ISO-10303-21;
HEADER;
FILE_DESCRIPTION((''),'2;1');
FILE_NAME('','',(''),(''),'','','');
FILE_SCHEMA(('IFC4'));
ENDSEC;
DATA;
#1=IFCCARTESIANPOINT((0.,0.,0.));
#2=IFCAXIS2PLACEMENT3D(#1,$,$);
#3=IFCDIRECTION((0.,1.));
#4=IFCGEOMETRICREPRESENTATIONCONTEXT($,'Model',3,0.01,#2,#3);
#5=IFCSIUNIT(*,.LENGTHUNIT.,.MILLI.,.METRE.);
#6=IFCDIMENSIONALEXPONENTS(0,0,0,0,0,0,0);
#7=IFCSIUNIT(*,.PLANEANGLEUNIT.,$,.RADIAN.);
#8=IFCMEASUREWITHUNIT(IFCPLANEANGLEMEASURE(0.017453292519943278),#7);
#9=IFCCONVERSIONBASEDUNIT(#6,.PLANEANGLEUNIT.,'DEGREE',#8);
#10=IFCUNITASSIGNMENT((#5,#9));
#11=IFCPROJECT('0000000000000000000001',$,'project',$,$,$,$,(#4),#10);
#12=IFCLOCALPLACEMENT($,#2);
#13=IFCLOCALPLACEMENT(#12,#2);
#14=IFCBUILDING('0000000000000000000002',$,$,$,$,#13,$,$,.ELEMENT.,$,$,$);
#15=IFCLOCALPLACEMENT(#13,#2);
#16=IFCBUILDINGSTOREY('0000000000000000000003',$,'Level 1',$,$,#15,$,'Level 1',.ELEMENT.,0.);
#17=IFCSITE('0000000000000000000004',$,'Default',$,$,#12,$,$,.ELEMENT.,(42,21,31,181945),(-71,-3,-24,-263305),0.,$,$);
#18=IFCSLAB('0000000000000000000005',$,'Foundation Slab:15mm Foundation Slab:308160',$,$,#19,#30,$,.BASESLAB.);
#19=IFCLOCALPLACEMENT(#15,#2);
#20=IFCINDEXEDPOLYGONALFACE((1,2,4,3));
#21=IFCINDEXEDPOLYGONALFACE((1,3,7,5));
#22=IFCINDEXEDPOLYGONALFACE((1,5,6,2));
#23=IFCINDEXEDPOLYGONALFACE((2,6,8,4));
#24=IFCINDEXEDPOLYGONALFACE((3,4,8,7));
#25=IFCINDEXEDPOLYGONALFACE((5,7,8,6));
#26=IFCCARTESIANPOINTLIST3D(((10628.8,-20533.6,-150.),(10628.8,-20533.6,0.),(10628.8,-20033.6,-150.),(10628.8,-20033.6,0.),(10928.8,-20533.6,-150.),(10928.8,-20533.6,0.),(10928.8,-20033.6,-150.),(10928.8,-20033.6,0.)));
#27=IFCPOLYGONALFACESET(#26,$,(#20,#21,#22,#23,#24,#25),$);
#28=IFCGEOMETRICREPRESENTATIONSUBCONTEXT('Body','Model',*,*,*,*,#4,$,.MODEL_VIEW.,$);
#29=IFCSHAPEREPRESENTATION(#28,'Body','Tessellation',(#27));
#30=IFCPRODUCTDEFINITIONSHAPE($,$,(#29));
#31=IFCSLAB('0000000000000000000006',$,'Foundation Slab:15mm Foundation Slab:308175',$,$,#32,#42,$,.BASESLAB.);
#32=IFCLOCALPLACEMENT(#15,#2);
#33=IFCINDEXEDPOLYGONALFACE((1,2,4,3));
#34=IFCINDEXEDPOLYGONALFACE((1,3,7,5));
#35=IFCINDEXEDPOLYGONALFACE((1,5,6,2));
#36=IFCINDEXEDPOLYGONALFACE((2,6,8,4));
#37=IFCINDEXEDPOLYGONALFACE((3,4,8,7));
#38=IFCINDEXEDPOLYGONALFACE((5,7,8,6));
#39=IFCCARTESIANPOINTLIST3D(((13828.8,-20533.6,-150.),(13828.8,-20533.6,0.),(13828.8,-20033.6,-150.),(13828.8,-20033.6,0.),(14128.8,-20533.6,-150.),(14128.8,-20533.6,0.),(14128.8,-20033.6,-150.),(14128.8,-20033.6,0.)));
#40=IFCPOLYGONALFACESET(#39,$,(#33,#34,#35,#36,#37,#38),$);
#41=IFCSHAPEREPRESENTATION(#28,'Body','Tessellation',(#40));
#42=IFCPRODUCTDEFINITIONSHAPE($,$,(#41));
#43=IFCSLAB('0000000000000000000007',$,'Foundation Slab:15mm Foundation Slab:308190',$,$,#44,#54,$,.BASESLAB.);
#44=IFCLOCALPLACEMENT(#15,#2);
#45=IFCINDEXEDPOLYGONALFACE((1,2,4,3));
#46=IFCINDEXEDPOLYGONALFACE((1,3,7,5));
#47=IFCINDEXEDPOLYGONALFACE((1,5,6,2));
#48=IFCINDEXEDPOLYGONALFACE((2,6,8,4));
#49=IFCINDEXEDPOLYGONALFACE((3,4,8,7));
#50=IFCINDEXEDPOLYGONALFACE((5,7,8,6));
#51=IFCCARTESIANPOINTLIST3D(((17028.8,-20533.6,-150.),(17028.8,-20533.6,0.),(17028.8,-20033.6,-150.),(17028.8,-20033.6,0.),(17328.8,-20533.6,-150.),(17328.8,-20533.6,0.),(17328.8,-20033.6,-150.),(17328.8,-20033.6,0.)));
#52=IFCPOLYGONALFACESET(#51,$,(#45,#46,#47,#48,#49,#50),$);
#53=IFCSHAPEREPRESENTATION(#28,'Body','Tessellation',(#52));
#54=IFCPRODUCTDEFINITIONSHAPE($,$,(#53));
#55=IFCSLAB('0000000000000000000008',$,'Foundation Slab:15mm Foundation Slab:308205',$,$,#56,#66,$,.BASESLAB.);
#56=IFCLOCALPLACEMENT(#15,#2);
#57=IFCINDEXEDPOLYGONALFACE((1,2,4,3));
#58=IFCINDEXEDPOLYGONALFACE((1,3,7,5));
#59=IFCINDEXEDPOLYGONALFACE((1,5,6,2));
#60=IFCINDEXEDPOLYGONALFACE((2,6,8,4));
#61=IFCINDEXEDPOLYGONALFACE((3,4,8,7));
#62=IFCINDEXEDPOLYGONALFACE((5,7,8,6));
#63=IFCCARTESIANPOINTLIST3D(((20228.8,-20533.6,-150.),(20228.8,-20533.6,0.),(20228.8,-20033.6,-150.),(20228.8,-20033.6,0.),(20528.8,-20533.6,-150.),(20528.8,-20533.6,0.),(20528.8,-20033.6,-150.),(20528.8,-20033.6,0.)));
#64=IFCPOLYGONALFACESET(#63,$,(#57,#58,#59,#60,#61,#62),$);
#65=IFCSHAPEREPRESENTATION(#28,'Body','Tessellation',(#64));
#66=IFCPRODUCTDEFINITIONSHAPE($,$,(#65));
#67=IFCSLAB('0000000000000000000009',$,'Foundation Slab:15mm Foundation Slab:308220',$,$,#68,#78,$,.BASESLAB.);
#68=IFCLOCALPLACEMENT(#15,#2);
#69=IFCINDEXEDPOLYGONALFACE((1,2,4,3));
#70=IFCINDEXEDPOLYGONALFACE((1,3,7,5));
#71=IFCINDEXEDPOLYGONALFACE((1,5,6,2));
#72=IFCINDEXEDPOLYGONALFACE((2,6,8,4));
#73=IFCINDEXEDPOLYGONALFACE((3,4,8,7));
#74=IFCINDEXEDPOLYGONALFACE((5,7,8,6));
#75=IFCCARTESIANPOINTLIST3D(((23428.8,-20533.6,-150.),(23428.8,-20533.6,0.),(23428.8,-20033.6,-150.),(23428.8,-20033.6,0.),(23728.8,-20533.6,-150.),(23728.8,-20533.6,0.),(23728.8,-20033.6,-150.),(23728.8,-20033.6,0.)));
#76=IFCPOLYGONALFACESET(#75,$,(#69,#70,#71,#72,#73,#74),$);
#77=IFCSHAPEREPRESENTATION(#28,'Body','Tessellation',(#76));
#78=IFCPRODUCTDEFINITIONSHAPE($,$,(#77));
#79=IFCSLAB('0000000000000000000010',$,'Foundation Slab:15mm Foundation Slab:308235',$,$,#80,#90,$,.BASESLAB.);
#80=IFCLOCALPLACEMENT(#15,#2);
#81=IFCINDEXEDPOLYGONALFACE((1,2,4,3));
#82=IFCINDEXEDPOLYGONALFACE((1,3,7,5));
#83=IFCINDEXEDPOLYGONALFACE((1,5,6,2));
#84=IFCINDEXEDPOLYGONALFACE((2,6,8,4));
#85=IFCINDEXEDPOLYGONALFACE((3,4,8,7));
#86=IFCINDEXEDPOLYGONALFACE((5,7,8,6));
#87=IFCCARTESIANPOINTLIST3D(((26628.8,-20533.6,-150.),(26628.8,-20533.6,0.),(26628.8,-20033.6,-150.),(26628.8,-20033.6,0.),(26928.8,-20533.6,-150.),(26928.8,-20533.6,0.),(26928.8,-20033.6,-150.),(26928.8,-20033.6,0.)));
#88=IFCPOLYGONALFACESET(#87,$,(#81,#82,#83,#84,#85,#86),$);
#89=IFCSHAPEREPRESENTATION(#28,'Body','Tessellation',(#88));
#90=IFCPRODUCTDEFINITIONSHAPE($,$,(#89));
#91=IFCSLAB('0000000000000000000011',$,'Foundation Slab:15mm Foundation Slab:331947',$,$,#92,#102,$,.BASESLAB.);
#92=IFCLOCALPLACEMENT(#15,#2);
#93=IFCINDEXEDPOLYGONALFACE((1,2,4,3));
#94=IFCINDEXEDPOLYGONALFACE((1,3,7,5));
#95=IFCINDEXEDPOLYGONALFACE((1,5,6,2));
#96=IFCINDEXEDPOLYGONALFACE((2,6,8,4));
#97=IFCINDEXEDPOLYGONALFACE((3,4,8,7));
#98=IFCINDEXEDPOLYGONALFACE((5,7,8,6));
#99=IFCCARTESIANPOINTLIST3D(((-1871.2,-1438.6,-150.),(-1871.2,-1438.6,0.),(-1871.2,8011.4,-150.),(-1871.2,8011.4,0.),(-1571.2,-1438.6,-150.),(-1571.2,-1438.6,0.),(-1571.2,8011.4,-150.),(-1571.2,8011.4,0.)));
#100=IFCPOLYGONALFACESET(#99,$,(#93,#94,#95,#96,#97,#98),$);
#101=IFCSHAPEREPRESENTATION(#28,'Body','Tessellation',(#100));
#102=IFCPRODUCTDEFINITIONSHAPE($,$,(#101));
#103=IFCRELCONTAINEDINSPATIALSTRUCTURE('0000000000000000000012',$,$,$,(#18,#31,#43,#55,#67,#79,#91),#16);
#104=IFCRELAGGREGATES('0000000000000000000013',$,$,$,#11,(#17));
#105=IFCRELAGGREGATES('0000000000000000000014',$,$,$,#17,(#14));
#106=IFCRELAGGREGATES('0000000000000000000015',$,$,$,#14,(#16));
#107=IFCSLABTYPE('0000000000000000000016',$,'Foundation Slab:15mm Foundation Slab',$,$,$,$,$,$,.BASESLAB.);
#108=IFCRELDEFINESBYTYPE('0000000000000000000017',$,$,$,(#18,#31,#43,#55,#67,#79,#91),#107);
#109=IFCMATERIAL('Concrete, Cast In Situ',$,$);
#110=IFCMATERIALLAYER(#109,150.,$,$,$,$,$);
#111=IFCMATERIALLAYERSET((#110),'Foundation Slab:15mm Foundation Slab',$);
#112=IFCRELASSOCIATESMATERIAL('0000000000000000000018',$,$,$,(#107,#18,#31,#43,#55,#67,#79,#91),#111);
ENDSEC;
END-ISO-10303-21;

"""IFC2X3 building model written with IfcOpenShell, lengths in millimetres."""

from ifc_helpers import new_model, entity, si_unit, converted_unit, direction, frame, frame_2d, origin, origin_2d_with_axis, place, context, subcontext, project, spatial, rectangle, extrude, material, layer, layer_set, layer_usage, type_object, element, save


model = new_model("IFC2X3")

# Units and contexts
model_context = context("Model", 3, precision=0.01, world=origin(), true_north=direction((0.0, 1.0)))
body_context = subcontext(model_context, "Body", "Model", "MODEL_VIEW")
ifc_project = project(units=[si_unit("LENGTHUNIT", "METRE", prefix="MILLI"), converted_unit("PLANEANGLEUNIT", "DEGREE", entity("IfcPlaneAngleMeasure", 0.017453292519943278), si_unit("PLANEANGLEUNIT", "RADIAN"), dimensions=[0, 0, 0, 0, 0, 0, 0])], contexts=[model_context])

# Site, building, storey
site_placement = place(None, origin())
site = spatial("IfcSite", under=ifc_project, at=site_placement, Name="Default", CompositionType="ELEMENT", RefLatitude=(42, 21, 31, 181945), RefLongitude=(-71, -3, -24, -263305), RefElevation=0.0)
building_placement = place(site_placement, origin())
building = spatial("IfcBuilding", under=site, at=building_placement, CompositionType="ELEMENT")
storey_placement = place(building_placement, origin())
storey = spatial("IfcBuildingStorey", under=building, at=storey_placement, Name="Level 1", LongName="Level 1", CompositionType="ELEMENT", Elevation=0.0)

# Slabs
ifc_material_1 = material(Name="Concrete, Cast In Situ")
ifc_layer = layer(ifc_material_1, 150.0)
ifc_layer_set = layer_set([ifc_layer], Name="Foundation Slab:15mm Foundation Slab")
slab_type = type_object("IfcSlabType", Name="Foundation Slab:15mm Foundation Slab", PredefinedType="BASESLAB", material=ifc_layer_set)
ifc_layer_usage_1 = layer_usage(ifc_layer_set, "AXIS3", "POSITIVE", 0.0)
slab_1_placement = place(storey_placement, origin())
element("IfcSlab", 1, at=slab_1_placement, inside=storey, type_object=slab_type, material=ifc_layer_usage_1, Name="Foundation Slab:15mm Foundation Slab:308160", PredefinedType="BASESLAB", context=body_context, shape_type="SweptSolid", body=[
    extrude(rectangle(XDim=500.0, YDim=300.0, at=origin_2d_with_axis()), frame((10778.8, -20283.6, 0.0), z_axis=(0.0, 0.0, -1.0), x_axis=(0.0, 1.0, 0.0)), (0.0, 0.0, 1.0), 150.0),
])
ifc_layer_usage_2 = layer_usage(ifc_layer_set, "AXIS3", "POSITIVE", 0.0)
slab_2_placement = place(storey_placement, origin())
element("IfcSlab", 2, at=slab_2_placement, inside=storey, type_object=slab_type, material=ifc_layer_usage_2, Name="Foundation Slab:15mm Foundation Slab:308175", PredefinedType="BASESLAB", context=body_context, shape_type="SweptSolid", body=[
    extrude(rectangle(XDim=500.0, YDim=300.0, at=origin_2d_with_axis()), frame((13978.8, -20283.6, 0.0), z_axis=(0.0, 0.0, -1.0), x_axis=(0.0, 1.0, 0.0)), (0.0, 0.0, 1.0), 150.0),
])
ifc_layer_usage_3 = layer_usage(ifc_layer_set, "AXIS3", "POSITIVE", 0.0)
slab_3_placement = place(storey_placement, origin())
element("IfcSlab", 3, at=slab_3_placement, inside=storey, type_object=slab_type, material=ifc_layer_usage_3, Name="Foundation Slab:15mm Foundation Slab:308190", PredefinedType="BASESLAB", context=body_context, shape_type="SweptSolid", body=[
    extrude(rectangle(XDim=500.0, YDim=300.0, at=origin_2d_with_axis()), frame((17178.8, -20283.6, 0.0), z_axis=(0.0, 0.0, -1.0), x_axis=(0.0, 1.0, 0.0)), (0.0, 0.0, 1.0), 150.0),
])
ifc_layer_usage_4 = layer_usage(ifc_layer_set, "AXIS3", "POSITIVE", 0.0)
slab_4_placement = place(storey_placement, origin())
element("IfcSlab", 4, at=slab_4_placement, inside=storey, type_object=slab_type, material=ifc_layer_usage_4, Name="Foundation Slab:15mm Foundation Slab:308205", PredefinedType="BASESLAB", context=body_context, shape_type="SweptSolid", body=[
    extrude(rectangle(XDim=500.0, YDim=300.0, at=origin_2d_with_axis()), frame((20378.8, -20283.6, 0.0), z_axis=(0.0, 0.0, -1.0), x_axis=(0.0, 1.0, 0.0)), (0.0, 0.0, 1.0), 150.0),
])
ifc_layer_usage_5 = layer_usage(ifc_layer_set, "AXIS3", "POSITIVE", 0.0)
slab_5_placement = place(storey_placement, origin())
element("IfcSlab", 5, at=slab_5_placement, inside=storey, type_object=slab_type, material=ifc_layer_usage_5, Name="Foundation Slab:15mm Foundation Slab:308220", PredefinedType="BASESLAB", context=body_context, shape_type="SweptSolid", body=[
    extrude(rectangle(XDim=500.0, YDim=300.0, at=origin_2d_with_axis()), frame((23578.8, -20283.6, 0.0), z_axis=(0.0, 0.0, -1.0), x_axis=(0.0, 1.0, 0.0)), (0.0, 0.0, 1.0), 150.0),
])
ifc_layer_usage_6 = layer_usage(ifc_layer_set, "AXIS3", "POSITIVE", 0.0)
slab_6_placement = place(storey_placement, origin())
element("IfcSlab", 6, at=slab_6_placement, inside=storey, type_object=slab_type, material=ifc_layer_usage_6, Name="Foundation Slab:15mm Foundation Slab:308235", PredefinedType="BASESLAB", context=body_context, shape_type="SweptSolid", body=[
    extrude(rectangle(XDim=500.0, YDim=300.0, at=origin_2d_with_axis()), frame((26778.8, -20283.6, 0.0), z_axis=(0.0, 0.0, -1.0), x_axis=(0.0, 1.0, 0.0)), (0.0, 0.0, 1.0), 150.0),
])
ifc_layer_usage_7 = layer_usage(ifc_layer_set, "AXIS3", "POSITIVE", 0.0)
slab_7_placement = place(storey_placement, origin())
element("IfcSlab", 7, at=slab_7_placement, inside=storey, type_object=slab_type, material=ifc_layer_usage_7, Name="Foundation Slab:15mm Foundation Slab:331947", PredefinedType="BASESLAB", context=body_context, shape_type="SweptSolid", body=[
    extrude(rectangle(XDim=9450.0, YDim=300.0, at=frame_2d((0.0, 0.0), x_axis=(1.0, 0.0))), frame((-1721.2, 3286.4, 0.0), z_axis=(0.0, 0.0, -1.0), x_axis=(0.0, 1.0, 0.0)), (0.0, 0.0, 1.0), 150.0),
])

save(model, "model.ifc")
